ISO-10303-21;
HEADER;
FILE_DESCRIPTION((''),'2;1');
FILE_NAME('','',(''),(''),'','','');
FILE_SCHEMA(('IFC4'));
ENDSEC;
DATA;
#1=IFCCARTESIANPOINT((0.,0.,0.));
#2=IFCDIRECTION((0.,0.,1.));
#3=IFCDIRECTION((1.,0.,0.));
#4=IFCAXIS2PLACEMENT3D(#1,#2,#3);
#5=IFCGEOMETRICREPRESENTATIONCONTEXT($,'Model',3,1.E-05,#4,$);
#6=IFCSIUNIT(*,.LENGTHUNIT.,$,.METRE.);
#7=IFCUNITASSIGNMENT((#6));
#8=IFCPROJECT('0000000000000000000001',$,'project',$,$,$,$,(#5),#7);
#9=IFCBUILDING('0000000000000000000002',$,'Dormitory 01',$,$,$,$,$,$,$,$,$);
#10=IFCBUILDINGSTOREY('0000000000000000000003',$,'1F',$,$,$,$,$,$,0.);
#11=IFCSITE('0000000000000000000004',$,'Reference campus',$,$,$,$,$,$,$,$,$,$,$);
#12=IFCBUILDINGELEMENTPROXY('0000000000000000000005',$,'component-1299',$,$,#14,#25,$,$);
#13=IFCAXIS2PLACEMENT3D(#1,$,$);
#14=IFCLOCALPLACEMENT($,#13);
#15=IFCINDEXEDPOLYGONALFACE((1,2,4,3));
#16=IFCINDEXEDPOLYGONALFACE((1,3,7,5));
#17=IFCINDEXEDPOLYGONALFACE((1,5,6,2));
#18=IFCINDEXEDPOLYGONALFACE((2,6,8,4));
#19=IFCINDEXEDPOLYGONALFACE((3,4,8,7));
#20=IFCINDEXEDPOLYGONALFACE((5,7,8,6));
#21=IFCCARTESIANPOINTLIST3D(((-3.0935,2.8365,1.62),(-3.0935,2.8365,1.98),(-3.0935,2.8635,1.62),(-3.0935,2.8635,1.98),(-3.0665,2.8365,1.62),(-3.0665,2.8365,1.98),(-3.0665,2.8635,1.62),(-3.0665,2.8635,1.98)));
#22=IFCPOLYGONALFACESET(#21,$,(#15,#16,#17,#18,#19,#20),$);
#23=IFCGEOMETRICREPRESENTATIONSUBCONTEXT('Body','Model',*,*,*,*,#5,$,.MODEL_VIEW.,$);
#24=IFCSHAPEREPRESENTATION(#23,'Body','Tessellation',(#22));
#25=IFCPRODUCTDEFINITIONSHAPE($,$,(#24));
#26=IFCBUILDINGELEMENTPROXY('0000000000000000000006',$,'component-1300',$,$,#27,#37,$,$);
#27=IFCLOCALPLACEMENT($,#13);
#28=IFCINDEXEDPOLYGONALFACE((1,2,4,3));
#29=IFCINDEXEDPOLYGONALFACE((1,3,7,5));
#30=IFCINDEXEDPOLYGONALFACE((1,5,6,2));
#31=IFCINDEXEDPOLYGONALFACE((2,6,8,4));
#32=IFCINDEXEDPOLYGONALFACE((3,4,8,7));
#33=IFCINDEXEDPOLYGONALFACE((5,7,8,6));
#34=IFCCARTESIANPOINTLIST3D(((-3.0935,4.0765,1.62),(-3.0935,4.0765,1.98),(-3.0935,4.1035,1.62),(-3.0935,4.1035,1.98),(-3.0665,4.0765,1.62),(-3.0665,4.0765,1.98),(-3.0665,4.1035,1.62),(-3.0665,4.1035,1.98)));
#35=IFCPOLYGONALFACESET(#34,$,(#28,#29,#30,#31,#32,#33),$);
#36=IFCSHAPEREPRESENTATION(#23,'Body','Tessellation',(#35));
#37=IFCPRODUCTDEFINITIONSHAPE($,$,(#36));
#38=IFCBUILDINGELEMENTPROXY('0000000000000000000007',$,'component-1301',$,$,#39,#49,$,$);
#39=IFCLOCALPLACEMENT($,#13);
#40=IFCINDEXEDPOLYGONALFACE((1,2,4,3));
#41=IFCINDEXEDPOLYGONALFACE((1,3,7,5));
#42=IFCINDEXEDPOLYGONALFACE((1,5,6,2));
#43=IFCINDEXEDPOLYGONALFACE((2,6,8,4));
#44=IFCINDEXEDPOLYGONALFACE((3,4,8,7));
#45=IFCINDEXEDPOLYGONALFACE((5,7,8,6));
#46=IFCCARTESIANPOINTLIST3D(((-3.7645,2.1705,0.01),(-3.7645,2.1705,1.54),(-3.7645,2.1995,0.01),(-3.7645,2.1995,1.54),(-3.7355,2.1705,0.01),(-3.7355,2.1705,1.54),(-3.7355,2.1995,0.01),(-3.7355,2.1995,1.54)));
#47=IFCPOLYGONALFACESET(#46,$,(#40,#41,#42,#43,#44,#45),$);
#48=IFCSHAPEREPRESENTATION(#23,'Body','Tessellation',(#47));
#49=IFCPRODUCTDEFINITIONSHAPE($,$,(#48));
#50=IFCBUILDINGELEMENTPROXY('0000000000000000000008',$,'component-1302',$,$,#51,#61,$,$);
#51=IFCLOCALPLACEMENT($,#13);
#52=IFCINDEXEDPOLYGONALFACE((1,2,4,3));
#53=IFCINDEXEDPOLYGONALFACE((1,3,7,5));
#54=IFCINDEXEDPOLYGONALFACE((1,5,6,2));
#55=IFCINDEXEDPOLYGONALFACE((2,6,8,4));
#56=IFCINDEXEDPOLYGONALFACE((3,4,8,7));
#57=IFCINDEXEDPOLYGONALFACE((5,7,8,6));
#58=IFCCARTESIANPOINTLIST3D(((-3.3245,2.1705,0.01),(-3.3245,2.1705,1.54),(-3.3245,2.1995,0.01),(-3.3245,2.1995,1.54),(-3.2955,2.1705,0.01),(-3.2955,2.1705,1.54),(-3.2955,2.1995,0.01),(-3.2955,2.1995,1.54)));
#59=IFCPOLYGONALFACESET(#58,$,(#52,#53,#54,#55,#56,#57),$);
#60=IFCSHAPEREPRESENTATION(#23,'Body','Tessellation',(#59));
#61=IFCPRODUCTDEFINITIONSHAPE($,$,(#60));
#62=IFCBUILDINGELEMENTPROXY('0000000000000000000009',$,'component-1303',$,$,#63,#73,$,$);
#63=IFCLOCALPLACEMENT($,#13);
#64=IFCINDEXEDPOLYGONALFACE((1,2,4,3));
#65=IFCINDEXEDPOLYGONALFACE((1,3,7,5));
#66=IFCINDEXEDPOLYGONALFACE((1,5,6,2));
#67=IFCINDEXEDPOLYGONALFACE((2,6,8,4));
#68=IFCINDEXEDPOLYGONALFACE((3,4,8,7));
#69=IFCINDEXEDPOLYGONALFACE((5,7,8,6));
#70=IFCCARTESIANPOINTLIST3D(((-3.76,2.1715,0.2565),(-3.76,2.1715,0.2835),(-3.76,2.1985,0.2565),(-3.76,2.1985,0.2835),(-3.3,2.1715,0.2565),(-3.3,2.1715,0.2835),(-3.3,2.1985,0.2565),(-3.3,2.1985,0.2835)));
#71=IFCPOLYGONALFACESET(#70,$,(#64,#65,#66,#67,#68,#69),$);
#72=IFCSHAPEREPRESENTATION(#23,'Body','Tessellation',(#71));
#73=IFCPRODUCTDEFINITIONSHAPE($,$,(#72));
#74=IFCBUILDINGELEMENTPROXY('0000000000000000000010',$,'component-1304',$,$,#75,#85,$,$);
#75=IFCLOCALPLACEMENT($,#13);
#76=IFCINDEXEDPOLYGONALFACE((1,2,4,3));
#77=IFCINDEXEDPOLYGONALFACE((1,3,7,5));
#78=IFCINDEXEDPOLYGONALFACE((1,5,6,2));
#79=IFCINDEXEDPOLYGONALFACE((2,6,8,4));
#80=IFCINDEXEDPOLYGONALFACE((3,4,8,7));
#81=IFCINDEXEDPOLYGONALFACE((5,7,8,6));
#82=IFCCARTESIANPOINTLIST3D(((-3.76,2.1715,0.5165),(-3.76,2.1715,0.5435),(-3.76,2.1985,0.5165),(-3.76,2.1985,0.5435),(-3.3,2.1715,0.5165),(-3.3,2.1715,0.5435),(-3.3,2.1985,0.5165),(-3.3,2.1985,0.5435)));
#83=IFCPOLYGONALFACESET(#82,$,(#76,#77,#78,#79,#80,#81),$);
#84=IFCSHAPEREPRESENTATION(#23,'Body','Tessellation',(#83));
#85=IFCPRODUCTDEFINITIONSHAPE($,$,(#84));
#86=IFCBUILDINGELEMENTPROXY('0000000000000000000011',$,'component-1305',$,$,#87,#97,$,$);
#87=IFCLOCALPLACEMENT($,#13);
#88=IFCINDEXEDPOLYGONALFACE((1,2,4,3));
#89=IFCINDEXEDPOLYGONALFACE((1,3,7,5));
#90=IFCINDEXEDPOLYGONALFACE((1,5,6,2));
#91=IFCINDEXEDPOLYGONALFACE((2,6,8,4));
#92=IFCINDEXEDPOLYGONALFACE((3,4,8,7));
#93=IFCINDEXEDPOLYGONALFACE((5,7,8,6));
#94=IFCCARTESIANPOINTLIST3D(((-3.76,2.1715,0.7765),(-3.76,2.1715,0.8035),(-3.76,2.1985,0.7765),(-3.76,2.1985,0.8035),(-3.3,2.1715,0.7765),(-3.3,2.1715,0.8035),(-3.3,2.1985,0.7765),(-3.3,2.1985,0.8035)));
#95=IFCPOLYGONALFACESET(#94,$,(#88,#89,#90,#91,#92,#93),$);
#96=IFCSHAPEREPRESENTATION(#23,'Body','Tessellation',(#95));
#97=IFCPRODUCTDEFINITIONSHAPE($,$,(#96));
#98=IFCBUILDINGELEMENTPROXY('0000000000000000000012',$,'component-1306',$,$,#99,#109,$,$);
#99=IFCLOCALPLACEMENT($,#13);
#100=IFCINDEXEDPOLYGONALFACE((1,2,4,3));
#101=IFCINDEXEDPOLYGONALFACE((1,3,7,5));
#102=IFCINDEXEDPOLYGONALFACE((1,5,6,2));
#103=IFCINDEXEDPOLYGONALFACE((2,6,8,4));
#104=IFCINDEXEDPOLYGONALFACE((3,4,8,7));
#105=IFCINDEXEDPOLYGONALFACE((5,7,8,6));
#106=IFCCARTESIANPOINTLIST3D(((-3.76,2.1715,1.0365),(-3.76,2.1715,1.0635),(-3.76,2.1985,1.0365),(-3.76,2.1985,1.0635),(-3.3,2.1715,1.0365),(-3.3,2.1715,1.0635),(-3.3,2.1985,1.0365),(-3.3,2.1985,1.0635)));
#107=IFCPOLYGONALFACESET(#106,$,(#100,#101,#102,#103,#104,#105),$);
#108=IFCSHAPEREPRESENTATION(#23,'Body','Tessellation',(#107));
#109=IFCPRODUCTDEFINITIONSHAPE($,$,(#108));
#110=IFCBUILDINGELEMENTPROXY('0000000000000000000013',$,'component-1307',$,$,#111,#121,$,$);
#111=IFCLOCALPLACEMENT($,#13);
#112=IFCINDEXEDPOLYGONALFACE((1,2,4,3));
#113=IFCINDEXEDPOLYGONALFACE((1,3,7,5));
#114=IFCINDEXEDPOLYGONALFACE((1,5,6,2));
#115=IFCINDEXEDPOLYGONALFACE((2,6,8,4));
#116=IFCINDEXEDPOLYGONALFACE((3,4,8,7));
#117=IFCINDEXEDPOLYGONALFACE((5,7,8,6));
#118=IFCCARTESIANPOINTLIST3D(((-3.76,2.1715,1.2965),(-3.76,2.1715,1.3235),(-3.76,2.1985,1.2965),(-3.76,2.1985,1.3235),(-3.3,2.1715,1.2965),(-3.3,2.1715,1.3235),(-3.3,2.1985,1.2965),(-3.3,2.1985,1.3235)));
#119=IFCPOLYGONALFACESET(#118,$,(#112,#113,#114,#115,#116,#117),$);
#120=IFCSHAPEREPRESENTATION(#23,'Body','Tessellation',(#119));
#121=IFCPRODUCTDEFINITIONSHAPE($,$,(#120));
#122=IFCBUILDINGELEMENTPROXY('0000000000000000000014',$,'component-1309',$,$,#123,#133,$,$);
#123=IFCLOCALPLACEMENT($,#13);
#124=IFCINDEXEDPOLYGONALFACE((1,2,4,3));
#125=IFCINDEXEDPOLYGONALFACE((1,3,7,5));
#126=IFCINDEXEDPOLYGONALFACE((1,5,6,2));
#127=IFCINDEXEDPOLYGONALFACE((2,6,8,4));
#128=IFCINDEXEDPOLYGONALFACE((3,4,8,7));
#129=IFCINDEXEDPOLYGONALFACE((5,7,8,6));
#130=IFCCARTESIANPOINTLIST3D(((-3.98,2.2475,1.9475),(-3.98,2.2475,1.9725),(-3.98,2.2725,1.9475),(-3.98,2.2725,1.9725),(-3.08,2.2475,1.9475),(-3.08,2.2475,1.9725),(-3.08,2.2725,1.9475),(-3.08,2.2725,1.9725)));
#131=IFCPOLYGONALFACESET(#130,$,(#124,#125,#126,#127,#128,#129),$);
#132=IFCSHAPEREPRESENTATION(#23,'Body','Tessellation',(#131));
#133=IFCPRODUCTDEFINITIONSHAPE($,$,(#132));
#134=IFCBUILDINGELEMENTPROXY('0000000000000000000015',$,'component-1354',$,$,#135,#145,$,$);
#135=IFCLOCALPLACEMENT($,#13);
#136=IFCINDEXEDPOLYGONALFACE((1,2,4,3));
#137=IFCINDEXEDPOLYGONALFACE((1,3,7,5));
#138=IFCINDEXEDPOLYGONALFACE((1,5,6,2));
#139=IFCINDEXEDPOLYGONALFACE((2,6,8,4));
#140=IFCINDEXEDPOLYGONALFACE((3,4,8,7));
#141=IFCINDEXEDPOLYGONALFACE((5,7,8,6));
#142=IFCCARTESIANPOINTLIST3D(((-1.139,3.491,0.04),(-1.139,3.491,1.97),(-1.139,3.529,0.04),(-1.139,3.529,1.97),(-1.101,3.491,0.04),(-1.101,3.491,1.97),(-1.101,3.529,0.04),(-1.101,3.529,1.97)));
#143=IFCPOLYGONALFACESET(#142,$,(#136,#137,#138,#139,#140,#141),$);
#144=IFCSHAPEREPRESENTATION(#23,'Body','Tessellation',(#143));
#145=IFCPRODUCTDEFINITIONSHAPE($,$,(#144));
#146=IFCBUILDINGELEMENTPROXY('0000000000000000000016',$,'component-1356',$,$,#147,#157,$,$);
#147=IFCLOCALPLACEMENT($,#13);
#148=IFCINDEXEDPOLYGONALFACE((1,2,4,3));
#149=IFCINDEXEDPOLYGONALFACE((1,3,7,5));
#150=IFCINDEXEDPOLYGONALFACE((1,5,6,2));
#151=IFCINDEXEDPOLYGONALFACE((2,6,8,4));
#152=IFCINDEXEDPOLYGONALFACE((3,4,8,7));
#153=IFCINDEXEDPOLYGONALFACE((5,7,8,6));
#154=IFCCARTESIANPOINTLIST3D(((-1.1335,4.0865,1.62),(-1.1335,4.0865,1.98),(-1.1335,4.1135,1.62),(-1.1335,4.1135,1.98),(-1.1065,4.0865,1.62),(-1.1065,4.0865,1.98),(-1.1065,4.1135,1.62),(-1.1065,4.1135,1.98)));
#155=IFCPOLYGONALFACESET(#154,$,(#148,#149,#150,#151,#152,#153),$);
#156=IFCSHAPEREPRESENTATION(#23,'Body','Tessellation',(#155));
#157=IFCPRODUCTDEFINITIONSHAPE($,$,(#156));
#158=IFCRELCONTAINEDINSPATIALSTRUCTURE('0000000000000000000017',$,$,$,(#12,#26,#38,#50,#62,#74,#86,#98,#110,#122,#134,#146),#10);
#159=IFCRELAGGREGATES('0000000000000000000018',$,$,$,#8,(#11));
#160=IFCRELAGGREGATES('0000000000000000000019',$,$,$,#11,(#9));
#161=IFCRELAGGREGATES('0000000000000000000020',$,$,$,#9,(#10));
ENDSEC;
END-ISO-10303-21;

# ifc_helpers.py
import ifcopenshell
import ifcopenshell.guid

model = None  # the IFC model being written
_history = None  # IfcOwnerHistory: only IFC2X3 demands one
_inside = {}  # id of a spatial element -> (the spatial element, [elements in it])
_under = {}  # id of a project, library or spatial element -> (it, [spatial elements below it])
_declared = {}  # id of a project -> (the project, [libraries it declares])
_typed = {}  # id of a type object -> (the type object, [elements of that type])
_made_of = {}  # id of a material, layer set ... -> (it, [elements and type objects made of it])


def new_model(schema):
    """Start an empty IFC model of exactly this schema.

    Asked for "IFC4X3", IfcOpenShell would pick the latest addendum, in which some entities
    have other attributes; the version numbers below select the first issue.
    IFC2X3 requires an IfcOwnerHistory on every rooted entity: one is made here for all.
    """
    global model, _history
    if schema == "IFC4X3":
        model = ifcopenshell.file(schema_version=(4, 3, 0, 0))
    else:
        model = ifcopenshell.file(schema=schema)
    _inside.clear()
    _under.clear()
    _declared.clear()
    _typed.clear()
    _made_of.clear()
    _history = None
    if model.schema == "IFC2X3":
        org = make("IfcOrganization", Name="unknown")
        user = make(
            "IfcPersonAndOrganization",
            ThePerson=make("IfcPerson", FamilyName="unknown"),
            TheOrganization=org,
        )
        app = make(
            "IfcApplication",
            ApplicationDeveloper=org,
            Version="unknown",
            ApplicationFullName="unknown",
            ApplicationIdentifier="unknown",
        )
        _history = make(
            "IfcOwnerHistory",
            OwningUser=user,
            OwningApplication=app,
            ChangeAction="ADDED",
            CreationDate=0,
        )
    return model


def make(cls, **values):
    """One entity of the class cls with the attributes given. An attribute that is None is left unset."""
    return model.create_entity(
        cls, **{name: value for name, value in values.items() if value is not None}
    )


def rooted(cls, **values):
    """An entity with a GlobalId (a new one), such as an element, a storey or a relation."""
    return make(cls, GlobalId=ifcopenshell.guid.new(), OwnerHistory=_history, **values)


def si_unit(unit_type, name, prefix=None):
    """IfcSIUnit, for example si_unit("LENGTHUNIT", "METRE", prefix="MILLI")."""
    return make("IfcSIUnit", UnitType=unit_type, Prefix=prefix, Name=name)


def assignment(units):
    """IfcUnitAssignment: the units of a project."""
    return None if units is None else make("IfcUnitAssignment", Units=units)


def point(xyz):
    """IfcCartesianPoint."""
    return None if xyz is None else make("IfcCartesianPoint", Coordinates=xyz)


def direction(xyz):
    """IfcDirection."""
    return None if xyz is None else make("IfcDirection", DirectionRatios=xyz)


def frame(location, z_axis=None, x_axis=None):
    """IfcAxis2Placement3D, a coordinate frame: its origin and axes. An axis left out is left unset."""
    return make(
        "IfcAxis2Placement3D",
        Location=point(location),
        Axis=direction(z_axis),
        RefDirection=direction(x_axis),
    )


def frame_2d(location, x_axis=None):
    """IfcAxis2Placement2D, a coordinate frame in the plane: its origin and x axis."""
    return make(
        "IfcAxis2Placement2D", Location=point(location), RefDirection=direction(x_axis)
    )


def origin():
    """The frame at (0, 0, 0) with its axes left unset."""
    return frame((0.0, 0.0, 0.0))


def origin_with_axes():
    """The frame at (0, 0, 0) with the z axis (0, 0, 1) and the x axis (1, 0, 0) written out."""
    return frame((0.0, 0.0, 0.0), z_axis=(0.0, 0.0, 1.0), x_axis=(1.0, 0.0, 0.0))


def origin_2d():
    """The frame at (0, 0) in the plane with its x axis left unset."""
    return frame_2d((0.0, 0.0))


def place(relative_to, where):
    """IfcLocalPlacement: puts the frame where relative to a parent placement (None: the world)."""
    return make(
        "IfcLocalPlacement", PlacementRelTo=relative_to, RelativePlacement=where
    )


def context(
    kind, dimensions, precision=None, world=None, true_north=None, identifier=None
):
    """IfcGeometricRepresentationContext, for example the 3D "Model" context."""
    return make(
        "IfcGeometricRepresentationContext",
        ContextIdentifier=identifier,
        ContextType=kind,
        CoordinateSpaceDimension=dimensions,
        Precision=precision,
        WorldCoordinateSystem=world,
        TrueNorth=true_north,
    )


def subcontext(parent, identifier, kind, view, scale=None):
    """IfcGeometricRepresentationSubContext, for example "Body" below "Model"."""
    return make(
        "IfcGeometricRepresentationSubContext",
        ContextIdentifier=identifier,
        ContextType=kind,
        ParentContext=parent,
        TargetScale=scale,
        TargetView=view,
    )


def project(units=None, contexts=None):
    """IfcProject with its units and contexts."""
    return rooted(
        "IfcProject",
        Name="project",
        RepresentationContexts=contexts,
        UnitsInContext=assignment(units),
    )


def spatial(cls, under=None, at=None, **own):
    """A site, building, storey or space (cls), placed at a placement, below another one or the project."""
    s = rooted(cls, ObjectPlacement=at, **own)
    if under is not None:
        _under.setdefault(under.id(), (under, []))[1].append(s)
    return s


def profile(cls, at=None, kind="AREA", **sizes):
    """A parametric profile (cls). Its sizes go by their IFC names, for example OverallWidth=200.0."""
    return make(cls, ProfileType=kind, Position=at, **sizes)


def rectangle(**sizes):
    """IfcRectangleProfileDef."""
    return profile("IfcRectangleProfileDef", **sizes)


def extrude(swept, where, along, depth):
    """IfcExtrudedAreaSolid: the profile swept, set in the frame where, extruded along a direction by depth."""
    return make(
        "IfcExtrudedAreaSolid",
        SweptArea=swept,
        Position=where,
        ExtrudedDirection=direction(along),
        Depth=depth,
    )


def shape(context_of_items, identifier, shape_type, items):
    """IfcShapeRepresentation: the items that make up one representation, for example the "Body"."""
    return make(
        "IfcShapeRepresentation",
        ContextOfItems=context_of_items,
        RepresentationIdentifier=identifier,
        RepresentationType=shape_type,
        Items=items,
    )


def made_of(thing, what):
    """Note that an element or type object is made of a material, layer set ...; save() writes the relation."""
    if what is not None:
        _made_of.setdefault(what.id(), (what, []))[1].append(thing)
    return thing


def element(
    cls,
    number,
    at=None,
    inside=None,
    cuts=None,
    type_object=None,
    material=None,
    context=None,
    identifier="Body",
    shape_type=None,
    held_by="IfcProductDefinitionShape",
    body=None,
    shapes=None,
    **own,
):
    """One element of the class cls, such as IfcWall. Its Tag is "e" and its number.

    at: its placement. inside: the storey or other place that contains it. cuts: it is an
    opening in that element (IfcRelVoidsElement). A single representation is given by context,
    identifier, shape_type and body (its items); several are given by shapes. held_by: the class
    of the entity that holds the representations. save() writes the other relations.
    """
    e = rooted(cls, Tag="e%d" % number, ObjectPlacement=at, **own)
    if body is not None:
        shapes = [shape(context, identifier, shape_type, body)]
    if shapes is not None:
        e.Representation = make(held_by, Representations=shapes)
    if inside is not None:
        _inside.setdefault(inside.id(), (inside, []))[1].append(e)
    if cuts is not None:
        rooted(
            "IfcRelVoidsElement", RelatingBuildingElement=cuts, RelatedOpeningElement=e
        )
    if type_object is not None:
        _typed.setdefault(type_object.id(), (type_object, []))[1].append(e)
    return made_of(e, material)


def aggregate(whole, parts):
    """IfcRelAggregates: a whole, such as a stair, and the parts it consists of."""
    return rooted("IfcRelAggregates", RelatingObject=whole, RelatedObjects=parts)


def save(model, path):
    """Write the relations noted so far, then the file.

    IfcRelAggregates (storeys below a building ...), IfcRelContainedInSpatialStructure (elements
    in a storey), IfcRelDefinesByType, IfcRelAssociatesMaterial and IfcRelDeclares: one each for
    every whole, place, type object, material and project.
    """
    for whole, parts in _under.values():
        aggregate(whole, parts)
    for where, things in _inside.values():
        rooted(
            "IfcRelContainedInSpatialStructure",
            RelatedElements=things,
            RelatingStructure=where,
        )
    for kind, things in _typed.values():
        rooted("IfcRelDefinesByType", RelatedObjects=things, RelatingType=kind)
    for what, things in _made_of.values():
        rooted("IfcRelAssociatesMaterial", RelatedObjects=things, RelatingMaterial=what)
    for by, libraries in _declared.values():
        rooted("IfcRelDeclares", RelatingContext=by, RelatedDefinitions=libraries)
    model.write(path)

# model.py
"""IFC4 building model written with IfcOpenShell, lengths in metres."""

from ifc_helpers import new_model, si_unit, frame, origin, origin_with_axes, origin_2d, place, context, subcontext, project, spatial, rectangle, extrude, element, save


model = new_model("IFC4")

# Units and contexts
model_context = context("Model", 3, precision=1e-05, world=origin_with_axes())
body_context = subcontext(model_context, "Body", "Model", "MODEL_VIEW")
ifc_project = project(units=[si_unit("LENGTHUNIT", "METRE")], contexts=[model_context])

# Site, building, storey
site = spatial("IfcSite", under=ifc_project, Name="Reference campus")
building = spatial("IfcBuilding", under=site, Name="Dormitory 01")
storey = spatial("IfcBuildingStorey", under=building, Name="1F", Elevation=0.0)

# Building element proxies
for number, where, z_axis, x_axis, name in (
    (1, (-3.08, 2.85, 1.62), (0.0, 0.0, 1.0), (1.0, 0.0, 0.0), "component-1299"),
    (2, (-3.08, 4.09, 1.62), (0.0, 0.0, 1.0), (1.0, 0.0, 0.0), "component-1300"),
):
    element("IfcBuildingElementProxy", number, at=place(None, frame(where, z_axis=z_axis, x_axis=x_axis)), inside=storey, Name=name, context=body_context, shape_type="SweptSolid", body=[
        extrude(rectangle(XDim=0.027, YDim=0.027, at=origin_2d()), origin(), (0.0, 0.0, 1.0), 0.36),
    ])
for number, where, z_axis, x_axis, name in (
    (3, (-3.75, 2.185, 0.01), (0.0, 0.0, 1.0), (1.0, 0.0, 0.0), "component-1301"),
    (4, (-3.31, 2.185, 0.01), (0.0, 0.0, 1.0), (1.0, 0.0, 0.0), "component-1302"),
):
    element("IfcBuildingElementProxy", number, at=place(None, frame(where, z_axis=z_axis, x_axis=x_axis)), inside=storey, Name=name, context=body_context, shape_type="SweptSolid", body=[
        extrude(rectangle(XDim=0.029, YDim=0.029, at=origin_2d()), origin(), (0.0, 0.0, 1.0), 1.53),
    ])
for number, where, z_axis, x_axis, name in (
    (5, (-3.53, 2.185, 0.2565), (0.0, 0.0, 1.0), (1.0, 0.0, 0.0), "component-1303"),
    (6, (-3.53, 2.185, 0.5165), (0.0, 0.0, 1.0), (1.0, 0.0, 0.0), "component-1304"),
    (7, (-3.53, 2.185, 0.7765), (0.0, 0.0, 1.0), (1.0, 0.0, 0.0), "component-1305"),
    (8, (-3.53, 2.185, 1.0365), (0.0, 0.0, 1.0), (1.0, 0.0, 0.0), "component-1306"),
    (9, (-3.53, 2.185, 1.2965), (0.0, 0.0, 1.0), (1.0, 0.0, 0.0), "component-1307"),
):
    element("IfcBuildingElementProxy", number, at=place(None, frame(where, z_axis=z_axis, x_axis=x_axis)), inside=storey, Name=name, context=body_context, shape_type="SweptSolid", body=[
        extrude(rectangle(XDim=0.46, YDim=0.027, at=origin_2d()), origin(), (0.0, 0.0, 1.0), 0.027),
    ])
proxy_1_placement = place(None, frame((-3.53, 2.26, 1.9475), z_axis=(0.0, 0.0, 1.0), x_axis=(1.0, 0.0, 0.0)))
element("IfcBuildingElementProxy", 10, at=proxy_1_placement, inside=storey, Name="component-1309", context=body_context, shape_type="SweptSolid", body=[
    extrude(rectangle(XDim=0.9, YDim=0.025, at=origin_2d()), origin(), (0.0, 0.0, 1.0), 0.025),
])
proxy_2_placement = place(None, frame((-1.12, 3.51, 0.04), z_axis=(0.0, 0.0, 1.0), x_axis=(1.0, 0.0, 0.0)))
element("IfcBuildingElementProxy", 11, at=proxy_2_placement, inside=storey, Name="component-1354", context=body_context, shape_type="SweptSolid", body=[
    extrude(rectangle(XDim=0.038, YDim=0.038, at=origin_2d()), origin(), (0.0, 0.0, 1.0), 1.93),
])
proxy_3_placement = place(None, frame((-1.12, 4.1, 1.62), z_axis=(0.0, 0.0, 1.0), x_axis=(1.0, 0.0, 0.0)))
element("IfcBuildingElementProxy", 12, at=proxy_3_placement, inside=storey, Name="component-1356", context=body_context, shape_type="SweptSolid", body=[
    extrude(rectangle(XDim=0.027, YDim=0.027, at=origin_2d()), origin(), (0.0, 0.0, 1.0), 0.36),
])

save(model, "model.ifc")
